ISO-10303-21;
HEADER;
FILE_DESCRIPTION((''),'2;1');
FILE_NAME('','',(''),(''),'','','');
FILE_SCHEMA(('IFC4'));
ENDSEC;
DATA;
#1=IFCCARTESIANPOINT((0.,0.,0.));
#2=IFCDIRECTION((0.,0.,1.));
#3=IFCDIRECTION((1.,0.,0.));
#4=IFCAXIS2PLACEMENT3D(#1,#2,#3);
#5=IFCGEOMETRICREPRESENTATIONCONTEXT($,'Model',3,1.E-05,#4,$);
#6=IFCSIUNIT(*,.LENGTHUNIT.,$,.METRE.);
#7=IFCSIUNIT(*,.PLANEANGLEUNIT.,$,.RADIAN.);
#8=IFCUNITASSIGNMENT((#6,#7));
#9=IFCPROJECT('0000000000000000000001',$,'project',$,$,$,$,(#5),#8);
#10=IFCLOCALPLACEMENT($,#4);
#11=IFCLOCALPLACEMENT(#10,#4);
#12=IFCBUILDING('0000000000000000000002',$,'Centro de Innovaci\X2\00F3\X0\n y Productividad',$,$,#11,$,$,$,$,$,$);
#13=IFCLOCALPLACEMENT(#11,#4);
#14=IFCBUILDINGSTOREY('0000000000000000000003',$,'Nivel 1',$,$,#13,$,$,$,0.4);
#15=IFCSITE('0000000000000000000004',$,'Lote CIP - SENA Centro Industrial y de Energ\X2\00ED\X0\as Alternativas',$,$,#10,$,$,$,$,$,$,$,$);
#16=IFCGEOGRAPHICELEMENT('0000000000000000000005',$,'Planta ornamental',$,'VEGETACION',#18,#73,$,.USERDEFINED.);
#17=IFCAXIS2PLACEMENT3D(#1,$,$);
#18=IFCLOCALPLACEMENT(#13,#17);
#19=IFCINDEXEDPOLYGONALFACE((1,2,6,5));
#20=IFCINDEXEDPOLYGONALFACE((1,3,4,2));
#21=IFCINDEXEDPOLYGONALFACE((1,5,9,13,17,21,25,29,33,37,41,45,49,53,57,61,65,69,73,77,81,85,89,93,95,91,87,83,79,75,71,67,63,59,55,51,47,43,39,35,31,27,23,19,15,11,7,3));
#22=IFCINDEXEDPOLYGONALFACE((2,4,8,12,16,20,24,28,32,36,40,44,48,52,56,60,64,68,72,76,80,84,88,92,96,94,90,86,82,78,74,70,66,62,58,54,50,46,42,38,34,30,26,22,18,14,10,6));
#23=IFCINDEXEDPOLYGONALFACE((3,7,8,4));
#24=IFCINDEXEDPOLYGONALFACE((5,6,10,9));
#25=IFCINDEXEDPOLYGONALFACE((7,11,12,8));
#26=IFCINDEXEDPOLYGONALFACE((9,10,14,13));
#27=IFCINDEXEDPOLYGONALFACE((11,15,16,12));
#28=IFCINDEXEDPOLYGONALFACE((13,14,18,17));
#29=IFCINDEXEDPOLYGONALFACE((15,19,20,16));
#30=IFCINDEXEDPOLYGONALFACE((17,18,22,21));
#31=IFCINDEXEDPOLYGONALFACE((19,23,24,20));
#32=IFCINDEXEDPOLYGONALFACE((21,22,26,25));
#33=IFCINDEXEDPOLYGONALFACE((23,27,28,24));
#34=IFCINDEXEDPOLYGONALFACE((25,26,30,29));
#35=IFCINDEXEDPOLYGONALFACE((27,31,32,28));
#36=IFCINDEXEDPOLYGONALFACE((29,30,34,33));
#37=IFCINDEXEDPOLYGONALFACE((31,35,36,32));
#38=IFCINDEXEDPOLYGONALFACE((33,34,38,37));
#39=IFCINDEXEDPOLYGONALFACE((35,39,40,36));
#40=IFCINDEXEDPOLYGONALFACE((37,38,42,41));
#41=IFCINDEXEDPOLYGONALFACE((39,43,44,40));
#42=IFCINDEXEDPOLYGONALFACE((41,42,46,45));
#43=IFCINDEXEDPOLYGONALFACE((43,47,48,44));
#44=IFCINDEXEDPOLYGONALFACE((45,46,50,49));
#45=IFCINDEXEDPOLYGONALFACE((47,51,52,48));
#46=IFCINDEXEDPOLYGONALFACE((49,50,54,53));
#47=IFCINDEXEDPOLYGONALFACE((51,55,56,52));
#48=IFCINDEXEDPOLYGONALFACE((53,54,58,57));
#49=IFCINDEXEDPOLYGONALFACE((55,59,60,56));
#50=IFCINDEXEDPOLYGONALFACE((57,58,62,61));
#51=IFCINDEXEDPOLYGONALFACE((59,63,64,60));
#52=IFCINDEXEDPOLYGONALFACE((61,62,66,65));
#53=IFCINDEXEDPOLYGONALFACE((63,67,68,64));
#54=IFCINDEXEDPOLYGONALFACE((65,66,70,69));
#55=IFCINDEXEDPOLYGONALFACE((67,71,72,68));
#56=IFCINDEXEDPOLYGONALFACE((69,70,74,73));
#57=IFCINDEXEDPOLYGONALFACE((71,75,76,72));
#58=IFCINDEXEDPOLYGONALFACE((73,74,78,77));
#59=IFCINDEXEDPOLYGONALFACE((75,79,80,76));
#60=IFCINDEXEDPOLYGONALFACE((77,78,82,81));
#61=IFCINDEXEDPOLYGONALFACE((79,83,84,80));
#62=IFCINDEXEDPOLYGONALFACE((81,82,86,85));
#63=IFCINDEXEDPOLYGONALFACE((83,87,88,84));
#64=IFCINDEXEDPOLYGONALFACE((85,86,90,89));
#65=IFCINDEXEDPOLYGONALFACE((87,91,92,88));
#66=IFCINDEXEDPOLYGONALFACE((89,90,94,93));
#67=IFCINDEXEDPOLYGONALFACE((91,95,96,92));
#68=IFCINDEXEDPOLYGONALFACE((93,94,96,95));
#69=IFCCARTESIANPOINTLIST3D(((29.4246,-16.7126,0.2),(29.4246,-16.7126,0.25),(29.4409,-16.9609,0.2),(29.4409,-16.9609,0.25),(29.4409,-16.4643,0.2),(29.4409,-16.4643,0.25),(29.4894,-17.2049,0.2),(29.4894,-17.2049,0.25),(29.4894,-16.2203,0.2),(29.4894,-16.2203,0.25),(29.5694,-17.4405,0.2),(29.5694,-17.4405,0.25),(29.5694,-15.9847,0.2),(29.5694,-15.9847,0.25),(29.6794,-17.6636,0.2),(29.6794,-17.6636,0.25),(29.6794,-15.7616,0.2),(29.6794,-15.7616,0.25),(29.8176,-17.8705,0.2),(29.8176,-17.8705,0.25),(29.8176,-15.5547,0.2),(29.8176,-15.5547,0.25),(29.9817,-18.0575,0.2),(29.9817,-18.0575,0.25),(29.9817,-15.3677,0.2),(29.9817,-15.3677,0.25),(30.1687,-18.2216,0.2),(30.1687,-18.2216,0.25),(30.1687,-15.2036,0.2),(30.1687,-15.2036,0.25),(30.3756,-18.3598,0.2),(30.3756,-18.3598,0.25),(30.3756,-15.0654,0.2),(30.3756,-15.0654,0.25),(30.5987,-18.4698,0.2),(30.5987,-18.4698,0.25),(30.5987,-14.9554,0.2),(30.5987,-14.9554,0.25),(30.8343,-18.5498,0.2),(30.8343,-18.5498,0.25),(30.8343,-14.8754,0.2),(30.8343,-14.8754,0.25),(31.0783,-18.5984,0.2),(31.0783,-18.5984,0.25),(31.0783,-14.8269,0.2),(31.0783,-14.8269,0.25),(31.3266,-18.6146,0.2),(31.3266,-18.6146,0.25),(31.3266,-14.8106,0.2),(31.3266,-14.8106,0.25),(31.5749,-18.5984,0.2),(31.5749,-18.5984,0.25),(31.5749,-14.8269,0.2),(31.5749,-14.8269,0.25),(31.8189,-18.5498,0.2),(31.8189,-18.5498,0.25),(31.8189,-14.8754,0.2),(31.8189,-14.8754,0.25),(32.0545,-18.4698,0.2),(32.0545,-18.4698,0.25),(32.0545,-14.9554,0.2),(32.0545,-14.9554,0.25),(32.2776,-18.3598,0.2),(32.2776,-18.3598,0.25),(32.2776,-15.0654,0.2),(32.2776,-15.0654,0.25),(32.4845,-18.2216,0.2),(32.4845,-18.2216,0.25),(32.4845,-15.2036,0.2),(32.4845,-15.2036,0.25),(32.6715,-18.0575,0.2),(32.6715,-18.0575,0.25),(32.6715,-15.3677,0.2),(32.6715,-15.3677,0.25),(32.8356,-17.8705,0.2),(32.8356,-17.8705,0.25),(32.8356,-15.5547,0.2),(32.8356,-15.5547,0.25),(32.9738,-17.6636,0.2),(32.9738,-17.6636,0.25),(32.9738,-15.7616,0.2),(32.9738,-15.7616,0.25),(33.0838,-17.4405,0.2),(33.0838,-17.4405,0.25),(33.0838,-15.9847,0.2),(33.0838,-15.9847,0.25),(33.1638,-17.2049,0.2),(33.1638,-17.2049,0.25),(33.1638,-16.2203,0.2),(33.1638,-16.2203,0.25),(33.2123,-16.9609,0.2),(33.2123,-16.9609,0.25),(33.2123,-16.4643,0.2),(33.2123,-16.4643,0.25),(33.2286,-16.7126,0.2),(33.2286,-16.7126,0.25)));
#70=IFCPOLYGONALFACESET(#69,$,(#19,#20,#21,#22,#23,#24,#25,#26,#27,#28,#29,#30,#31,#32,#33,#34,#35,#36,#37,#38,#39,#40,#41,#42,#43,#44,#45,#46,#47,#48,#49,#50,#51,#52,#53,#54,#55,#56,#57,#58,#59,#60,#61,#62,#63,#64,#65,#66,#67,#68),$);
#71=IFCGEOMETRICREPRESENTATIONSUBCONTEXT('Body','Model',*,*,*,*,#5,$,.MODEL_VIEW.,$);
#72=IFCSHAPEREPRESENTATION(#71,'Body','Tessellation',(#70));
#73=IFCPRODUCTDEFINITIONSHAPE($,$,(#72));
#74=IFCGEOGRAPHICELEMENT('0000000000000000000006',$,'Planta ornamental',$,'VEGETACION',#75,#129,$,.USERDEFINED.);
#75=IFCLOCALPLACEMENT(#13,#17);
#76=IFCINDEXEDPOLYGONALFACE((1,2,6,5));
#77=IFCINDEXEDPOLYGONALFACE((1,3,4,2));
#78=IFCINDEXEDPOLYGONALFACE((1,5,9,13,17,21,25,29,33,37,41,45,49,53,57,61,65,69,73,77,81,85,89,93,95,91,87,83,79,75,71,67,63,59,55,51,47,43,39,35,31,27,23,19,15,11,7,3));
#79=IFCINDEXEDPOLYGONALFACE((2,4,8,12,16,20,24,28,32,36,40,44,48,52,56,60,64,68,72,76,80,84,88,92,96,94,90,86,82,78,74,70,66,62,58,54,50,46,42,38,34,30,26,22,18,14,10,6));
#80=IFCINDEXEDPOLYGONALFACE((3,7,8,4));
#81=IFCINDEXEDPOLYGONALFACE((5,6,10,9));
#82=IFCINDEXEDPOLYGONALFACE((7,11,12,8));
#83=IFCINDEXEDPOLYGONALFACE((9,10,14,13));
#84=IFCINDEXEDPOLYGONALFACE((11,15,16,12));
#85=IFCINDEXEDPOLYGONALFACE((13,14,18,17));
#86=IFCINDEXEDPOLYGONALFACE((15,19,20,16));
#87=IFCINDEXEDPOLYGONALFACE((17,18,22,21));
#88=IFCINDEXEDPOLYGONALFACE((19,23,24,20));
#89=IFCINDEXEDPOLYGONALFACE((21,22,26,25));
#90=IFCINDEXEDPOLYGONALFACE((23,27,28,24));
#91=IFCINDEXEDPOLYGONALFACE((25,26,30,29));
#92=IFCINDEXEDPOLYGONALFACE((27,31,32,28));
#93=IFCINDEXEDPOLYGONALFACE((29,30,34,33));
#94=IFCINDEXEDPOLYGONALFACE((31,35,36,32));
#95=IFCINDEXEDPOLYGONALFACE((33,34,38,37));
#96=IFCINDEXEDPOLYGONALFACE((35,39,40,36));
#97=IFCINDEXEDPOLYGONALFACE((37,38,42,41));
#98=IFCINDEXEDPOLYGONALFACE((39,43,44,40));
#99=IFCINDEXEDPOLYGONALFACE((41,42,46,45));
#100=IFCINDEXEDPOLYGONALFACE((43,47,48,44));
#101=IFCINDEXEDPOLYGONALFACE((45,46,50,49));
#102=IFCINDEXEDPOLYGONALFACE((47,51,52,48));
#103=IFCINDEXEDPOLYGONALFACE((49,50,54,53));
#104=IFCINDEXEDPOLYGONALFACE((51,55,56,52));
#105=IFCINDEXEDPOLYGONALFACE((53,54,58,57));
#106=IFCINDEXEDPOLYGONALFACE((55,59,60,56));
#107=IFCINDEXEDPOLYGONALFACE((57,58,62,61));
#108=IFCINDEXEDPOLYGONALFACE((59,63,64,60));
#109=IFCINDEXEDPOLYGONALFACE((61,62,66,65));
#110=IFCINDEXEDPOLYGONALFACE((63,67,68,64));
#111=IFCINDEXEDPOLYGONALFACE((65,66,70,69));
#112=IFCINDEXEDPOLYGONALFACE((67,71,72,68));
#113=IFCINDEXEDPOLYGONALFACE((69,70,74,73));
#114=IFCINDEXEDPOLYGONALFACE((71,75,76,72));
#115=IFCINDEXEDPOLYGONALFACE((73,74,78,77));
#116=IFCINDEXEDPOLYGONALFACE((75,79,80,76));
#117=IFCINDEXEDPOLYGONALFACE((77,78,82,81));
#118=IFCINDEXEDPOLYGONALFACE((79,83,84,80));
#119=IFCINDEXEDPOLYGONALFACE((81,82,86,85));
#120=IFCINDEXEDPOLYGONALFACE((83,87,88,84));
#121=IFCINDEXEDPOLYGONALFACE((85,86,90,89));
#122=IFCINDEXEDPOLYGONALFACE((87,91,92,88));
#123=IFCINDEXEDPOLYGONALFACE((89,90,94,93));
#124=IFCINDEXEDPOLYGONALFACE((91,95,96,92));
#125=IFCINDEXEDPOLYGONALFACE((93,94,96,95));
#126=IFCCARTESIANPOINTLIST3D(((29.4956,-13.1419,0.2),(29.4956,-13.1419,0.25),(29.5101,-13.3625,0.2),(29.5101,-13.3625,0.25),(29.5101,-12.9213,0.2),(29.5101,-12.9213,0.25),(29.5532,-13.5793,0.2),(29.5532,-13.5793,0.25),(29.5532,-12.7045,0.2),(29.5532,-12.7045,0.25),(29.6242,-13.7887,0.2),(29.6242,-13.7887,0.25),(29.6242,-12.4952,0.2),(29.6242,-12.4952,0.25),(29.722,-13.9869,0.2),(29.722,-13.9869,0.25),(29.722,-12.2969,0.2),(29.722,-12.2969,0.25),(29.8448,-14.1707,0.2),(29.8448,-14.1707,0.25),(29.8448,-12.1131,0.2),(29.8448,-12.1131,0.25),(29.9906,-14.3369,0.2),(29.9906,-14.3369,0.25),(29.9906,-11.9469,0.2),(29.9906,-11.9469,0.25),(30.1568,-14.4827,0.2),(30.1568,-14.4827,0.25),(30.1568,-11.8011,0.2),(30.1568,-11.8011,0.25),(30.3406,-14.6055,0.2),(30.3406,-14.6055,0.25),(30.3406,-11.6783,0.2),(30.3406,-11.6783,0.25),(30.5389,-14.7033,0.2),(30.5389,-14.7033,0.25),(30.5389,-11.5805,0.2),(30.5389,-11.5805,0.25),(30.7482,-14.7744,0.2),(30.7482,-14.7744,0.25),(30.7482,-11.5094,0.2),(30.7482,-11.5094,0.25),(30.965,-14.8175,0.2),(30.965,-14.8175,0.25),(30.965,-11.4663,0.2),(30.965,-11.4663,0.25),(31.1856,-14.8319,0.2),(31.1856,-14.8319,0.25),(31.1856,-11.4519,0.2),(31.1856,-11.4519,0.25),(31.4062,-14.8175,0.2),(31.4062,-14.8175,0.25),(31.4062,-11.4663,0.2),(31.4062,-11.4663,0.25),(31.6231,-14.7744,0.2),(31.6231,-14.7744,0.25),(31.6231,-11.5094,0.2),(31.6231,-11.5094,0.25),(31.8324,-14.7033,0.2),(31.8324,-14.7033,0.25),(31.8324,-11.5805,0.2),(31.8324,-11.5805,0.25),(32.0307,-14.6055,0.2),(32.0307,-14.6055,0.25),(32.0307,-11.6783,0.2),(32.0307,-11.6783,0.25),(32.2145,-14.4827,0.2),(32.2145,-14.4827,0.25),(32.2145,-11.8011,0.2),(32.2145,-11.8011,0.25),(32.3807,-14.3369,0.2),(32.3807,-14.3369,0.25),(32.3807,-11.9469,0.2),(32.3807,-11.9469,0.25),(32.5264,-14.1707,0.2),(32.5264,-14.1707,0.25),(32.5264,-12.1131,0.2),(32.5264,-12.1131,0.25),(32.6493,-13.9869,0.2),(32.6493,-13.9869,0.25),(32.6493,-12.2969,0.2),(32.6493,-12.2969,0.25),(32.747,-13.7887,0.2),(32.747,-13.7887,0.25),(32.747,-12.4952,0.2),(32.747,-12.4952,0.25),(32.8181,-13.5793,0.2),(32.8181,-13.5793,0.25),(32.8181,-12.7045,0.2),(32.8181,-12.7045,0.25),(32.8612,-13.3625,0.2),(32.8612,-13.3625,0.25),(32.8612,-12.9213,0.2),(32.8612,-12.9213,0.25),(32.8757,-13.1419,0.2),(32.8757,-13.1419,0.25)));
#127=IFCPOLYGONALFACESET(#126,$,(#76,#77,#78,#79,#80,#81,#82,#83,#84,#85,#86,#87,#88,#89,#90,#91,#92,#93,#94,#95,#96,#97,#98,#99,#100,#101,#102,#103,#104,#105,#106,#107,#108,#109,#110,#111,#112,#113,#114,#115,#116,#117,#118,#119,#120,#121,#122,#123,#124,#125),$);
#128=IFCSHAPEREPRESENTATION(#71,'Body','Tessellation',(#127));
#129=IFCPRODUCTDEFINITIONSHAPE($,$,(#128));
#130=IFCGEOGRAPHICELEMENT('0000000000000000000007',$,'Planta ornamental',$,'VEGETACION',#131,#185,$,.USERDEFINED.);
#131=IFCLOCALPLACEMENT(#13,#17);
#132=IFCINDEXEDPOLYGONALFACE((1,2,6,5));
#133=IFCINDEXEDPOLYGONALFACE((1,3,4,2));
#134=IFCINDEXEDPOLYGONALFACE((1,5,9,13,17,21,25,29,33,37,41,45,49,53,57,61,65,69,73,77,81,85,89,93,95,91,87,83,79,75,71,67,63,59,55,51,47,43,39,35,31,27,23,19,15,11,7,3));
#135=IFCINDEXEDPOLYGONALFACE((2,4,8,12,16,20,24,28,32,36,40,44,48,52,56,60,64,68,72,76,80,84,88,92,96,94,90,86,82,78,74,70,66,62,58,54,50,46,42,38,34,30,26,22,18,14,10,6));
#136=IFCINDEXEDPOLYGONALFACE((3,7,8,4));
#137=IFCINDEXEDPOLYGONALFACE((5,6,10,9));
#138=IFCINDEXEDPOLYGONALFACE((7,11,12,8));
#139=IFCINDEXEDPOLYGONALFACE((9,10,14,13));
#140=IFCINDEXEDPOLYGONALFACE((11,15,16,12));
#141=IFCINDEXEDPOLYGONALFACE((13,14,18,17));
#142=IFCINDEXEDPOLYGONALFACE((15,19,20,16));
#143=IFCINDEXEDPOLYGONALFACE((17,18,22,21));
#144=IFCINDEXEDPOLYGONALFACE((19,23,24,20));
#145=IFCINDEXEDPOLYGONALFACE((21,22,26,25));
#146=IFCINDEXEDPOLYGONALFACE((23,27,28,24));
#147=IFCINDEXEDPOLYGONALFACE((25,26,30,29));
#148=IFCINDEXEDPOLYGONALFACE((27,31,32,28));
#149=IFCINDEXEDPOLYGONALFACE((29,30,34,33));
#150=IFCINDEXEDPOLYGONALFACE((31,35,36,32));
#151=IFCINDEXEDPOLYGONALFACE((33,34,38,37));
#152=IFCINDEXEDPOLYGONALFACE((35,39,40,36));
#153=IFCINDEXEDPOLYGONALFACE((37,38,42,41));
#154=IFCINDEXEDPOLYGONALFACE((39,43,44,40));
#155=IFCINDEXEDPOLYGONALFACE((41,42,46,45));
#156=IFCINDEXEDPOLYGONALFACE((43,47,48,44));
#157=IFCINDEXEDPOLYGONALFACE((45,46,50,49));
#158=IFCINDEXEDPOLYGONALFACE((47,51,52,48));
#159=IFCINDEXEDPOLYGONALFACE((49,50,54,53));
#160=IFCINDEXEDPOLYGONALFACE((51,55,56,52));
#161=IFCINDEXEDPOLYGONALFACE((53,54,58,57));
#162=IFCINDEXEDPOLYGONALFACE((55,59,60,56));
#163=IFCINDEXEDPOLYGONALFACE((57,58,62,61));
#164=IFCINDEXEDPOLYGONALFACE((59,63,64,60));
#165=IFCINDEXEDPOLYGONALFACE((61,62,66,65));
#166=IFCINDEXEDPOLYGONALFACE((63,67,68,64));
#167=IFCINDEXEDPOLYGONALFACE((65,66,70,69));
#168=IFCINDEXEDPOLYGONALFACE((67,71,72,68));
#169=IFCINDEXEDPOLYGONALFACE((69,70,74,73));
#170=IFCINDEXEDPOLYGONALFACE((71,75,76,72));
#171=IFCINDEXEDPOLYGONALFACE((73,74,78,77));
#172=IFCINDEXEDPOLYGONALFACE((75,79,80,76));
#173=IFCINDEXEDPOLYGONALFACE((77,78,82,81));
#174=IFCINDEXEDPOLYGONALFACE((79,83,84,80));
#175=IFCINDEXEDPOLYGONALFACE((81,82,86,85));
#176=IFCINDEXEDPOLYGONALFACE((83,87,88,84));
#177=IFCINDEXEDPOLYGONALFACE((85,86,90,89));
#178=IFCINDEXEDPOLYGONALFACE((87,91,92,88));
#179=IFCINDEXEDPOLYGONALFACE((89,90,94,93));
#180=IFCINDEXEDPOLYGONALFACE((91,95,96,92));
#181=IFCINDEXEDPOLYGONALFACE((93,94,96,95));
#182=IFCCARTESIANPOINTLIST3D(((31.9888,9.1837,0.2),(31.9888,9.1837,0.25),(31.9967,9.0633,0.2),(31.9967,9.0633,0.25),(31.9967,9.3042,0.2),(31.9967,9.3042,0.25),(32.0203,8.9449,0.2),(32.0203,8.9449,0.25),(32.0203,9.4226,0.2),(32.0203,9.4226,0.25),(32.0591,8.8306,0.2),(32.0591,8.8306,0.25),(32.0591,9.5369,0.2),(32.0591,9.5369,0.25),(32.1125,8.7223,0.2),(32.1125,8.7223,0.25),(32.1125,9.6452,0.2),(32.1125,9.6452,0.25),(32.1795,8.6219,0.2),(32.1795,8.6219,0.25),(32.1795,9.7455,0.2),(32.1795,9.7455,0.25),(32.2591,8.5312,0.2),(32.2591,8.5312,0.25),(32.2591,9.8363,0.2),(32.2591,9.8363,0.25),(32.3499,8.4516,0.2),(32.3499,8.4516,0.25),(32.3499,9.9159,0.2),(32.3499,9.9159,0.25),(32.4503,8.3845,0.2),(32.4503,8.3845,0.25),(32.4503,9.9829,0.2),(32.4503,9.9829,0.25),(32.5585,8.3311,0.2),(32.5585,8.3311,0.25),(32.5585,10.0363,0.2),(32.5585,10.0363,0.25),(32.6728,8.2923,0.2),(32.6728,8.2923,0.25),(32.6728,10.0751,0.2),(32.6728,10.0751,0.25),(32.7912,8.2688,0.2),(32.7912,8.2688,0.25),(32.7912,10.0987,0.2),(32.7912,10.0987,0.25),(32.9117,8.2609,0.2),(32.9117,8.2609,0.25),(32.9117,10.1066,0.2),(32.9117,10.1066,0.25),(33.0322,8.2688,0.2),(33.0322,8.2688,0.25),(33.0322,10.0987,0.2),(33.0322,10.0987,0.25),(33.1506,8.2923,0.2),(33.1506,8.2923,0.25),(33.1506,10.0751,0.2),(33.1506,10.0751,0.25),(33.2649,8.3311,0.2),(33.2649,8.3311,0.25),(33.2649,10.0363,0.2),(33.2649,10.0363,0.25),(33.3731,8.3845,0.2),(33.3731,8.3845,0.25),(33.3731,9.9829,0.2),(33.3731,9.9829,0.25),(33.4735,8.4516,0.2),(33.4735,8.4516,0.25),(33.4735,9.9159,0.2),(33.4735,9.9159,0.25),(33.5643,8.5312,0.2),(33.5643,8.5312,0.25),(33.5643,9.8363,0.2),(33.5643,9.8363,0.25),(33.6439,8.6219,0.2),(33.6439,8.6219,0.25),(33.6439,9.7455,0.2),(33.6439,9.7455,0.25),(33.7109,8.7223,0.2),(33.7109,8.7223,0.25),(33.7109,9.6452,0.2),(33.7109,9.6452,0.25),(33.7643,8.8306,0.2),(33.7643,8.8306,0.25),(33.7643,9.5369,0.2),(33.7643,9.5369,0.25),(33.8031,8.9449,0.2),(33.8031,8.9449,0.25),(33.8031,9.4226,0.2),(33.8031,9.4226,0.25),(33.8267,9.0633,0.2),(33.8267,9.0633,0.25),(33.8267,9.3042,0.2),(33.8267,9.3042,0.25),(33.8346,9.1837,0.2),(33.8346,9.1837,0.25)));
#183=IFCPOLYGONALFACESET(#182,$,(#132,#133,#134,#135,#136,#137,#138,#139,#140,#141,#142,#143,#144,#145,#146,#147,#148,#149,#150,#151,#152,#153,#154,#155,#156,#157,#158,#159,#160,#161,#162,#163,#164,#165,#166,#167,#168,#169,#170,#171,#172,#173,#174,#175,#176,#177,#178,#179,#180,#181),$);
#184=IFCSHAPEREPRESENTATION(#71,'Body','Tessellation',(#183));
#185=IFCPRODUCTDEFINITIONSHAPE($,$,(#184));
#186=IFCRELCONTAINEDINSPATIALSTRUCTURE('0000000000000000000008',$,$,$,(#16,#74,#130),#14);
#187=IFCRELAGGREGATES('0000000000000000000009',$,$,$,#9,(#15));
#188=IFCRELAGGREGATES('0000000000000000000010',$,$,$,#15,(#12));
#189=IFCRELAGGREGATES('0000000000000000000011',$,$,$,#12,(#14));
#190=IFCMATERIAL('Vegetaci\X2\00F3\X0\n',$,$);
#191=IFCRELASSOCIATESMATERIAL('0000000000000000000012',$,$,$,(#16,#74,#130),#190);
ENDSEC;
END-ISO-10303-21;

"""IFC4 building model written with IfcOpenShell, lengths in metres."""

from ifc_helpers import new_model, si_unit, frame, origin_with_axes, place, context, subcontext, project, spatial, polyline, outline, extrude, material, element, save


model = new_model("IFC4")

# Units and contexts
model_context = context("Model", 3, precision=1e-05, world=origin_with_axes())
body_context = subcontext(model_context, "Body", "Model", "MODEL_VIEW")
ifc_project = project(units=[si_unit("LENGTHUNIT", "METRE"), si_unit("PLANEANGLEUNIT", "RADIAN")], contexts=[model_context])

# Site, building, storey
site_placement = place(None, origin_with_axes())
site = spatial("IfcSite", under=ifc_project, at=site_placement, Name="Lote CIP - SENA Centro Industrial y de Energías Alternativas")
building_placement = place(site_placement, origin_with_axes())
building = spatial("IfcBuilding", under=site, at=building_placement, Name="Centro de Innovación y Productividad")
storey_placement = place(building_placement, origin_with_axes())
storey = spatial("IfcBuildingStorey", under=building, at=storey_placement, Name="Nivel 1", Elevation=0.4)

# Geographic elements
ifc_material = material(Name="Vegetación")
geographic_element_1_placement = place(storey_placement, origin_with_axes())
element("IfcGeographicElement", 1, at=geographic_element_1_placement, inside=storey, material=ifc_material, Name="Planta ornamental", ObjectType="VEGETACION", PredefinedType="USERDEFINED", context=body_context, shape_type="SweptSolid", body=[
    extrude(outline(polyline([(33.2286, -16.7126), (33.2123, -16.9609), (33.1638, -17.2049), (33.0838, -17.4405), (32.9738, -17.6636), (32.8356, -17.8705), (32.6715, -18.0575), (32.4845, -18.2216), (32.2776, -18.3598), (32.0545, -18.4698), (31.8189, -18.5498), (31.5749, -18.5984), (31.3266, -18.6146), (31.0783, -18.5984), (30.8343, -18.5498), (30.5987, -18.4698), (30.3756, -18.3598), (30.1687, -18.2216), (29.9817, -18.0575), (29.8176, -17.8705), (29.6794, -17.6636), (29.5694, -17.4405), (29.4894, -17.2049), (29.4409, -16.9609), (29.4246, -16.7126), (29.4409, -16.4643), (29.4894, -16.2203), (29.5694, -15.9847), (29.6794, -15.7616), (29.8176, -15.5547), (29.9817, -15.3677), (30.1687, -15.2036), (30.3756, -15.0654), (30.5987, -14.9554), (30.8343, -14.8754), (31.0783, -14.8269), (31.3266, -14.8106), (31.5749, -14.8269), (31.8189, -14.8754), (32.0545, -14.9554), (32.2776, -15.0654), (32.4845, -15.2036), (32.6715, -15.3677), (32.8356, -15.5547), (32.9738, -15.7616), (33.0838, -15.9847), (33.1638, -16.2203), (33.2123, -16.4643), (33.2286, -16.7126)])), frame((0.0, 0.0, 0.2)), (0.0, 0.0, 1.0), 0.05),
])
geographic_element_2_placement = place(storey_placement, origin_with_axes())
element("IfcGeographicElement", 2, at=geographic_element_2_placement, inside=storey, material=ifc_material, Name="Planta ornamental", ObjectType="VEGETACION", PredefinedType="USERDEFINED", context=body_context, shape_type="SweptSolid", body=[
    extrude(outline(polyline([(32.8757, -13.1419), (32.8612, -13.3625), (32.8181, -13.5793), (32.747, -13.7887), (32.6493, -13.9869), (32.5264, -14.1707), (32.3807, -14.3369), (32.2145, -14.4827), (32.0307, -14.6055), (31.8324, -14.7033), (31.6231, -14.7744), (31.4062, -14.8175), (31.1856, -14.8319), (30.965, -14.8175), (30.7482, -14.7744), (30.5389, -14.7033), (30.3406, -14.6055), (30.1568, -14.4827), (29.9906, -14.3369), (29.8448, -14.1707), (29.722, -13.9869), (29.6242, -13.7887), (29.5532, -13.5793), (29.5101, -13.3625), (29.4956, -13.1419), (29.5101, -12.9213), (29.5532, -12.7045), (29.6242, -12.4952), (29.722, -12.2969), (29.8448, -12.1131), (29.9906, -11.9469), (30.1568, -11.8011), (30.3406, -11.6783), (30.5389, -11.5805), (30.7482, -11.5094), (30.965, -11.4663), (31.1856, -11.4519), (31.4062, -11.4663), (31.6231, -11.5094), (31.8324, -11.5805), (32.0307, -11.6783), (32.2145, -11.8011), (32.3807, -11.9469), (32.5264, -12.1131), (32.6493, -12.2969), (32.747, -12.4952), (32.8181, -12.7045), (32.8612, -12.9213), (32.8757, -13.1419)])), frame((0.0, 0.0, 0.2)), (0.0, 0.0, 1.0), 0.05),
])
geographic_element_3_placement = place(storey_placement, origin_with_axes())
element("IfcGeographicElement", 3, at=geographic_element_3_placement, inside=storey, material=ifc_material, Name="Planta ornamental", ObjectType="VEGETACION", PredefinedType="USERDEFINED", context=body_context, shape_type="SweptSolid", body=[
    extrude(outline(polyline([(33.8346, 9.1837), (33.8267, 9.0633), (33.8031, 8.9449), (33.7643, 8.8306), (33.7109, 8.7223), (33.6439, 8.6219), (33.5643, 8.5312), (33.4735, 8.4516), (33.3731, 8.3845), (33.2649, 8.3311), (33.1506, 8.2923), (33.0322, 8.2688), (32.9117, 8.2609), (32.7912, 8.2688), (32.6728, 8.2923), (32.5585, 8.3311), (32.4503, 8.3845), (32.3499, 8.4516), (32.2591, 8.5312), (32.1795, 8.6219), (32.1125, 8.7223), (32.0591, 8.8306), (32.0203, 8.9449), (31.9967, 9.0633), (31.9888, 9.1837), (31.9967, 9.3042), (32.0203, 9.4226), (32.0591, 9.5369), (32.1125, 9.6452), (32.1795, 9.7455), (32.2591, 9.8363), (32.3499, 9.9159), (32.4503, 9.9829), (32.5585, 10.0363), (32.6728, 10.0751), (32.7912, 10.0987), (32.9117, 10.1066), (33.0322, 10.0987), (33.1506, 10.0751), (33.2649, 10.0363), (33.3731, 9.9829), (33.4735, 9.9159), (33.5643, 9.8363), (33.6439, 9.7455), (33.7109, 9.6452), (33.7643, 9.5369), (33.8031, 9.4226), (33.8267, 9.3042), (33.8346, 9.1837)])), frame((0.0, 0.0, 0.2)), (0.0, 0.0, 1.0), 0.05),
])

save(model, "model.ifc")
